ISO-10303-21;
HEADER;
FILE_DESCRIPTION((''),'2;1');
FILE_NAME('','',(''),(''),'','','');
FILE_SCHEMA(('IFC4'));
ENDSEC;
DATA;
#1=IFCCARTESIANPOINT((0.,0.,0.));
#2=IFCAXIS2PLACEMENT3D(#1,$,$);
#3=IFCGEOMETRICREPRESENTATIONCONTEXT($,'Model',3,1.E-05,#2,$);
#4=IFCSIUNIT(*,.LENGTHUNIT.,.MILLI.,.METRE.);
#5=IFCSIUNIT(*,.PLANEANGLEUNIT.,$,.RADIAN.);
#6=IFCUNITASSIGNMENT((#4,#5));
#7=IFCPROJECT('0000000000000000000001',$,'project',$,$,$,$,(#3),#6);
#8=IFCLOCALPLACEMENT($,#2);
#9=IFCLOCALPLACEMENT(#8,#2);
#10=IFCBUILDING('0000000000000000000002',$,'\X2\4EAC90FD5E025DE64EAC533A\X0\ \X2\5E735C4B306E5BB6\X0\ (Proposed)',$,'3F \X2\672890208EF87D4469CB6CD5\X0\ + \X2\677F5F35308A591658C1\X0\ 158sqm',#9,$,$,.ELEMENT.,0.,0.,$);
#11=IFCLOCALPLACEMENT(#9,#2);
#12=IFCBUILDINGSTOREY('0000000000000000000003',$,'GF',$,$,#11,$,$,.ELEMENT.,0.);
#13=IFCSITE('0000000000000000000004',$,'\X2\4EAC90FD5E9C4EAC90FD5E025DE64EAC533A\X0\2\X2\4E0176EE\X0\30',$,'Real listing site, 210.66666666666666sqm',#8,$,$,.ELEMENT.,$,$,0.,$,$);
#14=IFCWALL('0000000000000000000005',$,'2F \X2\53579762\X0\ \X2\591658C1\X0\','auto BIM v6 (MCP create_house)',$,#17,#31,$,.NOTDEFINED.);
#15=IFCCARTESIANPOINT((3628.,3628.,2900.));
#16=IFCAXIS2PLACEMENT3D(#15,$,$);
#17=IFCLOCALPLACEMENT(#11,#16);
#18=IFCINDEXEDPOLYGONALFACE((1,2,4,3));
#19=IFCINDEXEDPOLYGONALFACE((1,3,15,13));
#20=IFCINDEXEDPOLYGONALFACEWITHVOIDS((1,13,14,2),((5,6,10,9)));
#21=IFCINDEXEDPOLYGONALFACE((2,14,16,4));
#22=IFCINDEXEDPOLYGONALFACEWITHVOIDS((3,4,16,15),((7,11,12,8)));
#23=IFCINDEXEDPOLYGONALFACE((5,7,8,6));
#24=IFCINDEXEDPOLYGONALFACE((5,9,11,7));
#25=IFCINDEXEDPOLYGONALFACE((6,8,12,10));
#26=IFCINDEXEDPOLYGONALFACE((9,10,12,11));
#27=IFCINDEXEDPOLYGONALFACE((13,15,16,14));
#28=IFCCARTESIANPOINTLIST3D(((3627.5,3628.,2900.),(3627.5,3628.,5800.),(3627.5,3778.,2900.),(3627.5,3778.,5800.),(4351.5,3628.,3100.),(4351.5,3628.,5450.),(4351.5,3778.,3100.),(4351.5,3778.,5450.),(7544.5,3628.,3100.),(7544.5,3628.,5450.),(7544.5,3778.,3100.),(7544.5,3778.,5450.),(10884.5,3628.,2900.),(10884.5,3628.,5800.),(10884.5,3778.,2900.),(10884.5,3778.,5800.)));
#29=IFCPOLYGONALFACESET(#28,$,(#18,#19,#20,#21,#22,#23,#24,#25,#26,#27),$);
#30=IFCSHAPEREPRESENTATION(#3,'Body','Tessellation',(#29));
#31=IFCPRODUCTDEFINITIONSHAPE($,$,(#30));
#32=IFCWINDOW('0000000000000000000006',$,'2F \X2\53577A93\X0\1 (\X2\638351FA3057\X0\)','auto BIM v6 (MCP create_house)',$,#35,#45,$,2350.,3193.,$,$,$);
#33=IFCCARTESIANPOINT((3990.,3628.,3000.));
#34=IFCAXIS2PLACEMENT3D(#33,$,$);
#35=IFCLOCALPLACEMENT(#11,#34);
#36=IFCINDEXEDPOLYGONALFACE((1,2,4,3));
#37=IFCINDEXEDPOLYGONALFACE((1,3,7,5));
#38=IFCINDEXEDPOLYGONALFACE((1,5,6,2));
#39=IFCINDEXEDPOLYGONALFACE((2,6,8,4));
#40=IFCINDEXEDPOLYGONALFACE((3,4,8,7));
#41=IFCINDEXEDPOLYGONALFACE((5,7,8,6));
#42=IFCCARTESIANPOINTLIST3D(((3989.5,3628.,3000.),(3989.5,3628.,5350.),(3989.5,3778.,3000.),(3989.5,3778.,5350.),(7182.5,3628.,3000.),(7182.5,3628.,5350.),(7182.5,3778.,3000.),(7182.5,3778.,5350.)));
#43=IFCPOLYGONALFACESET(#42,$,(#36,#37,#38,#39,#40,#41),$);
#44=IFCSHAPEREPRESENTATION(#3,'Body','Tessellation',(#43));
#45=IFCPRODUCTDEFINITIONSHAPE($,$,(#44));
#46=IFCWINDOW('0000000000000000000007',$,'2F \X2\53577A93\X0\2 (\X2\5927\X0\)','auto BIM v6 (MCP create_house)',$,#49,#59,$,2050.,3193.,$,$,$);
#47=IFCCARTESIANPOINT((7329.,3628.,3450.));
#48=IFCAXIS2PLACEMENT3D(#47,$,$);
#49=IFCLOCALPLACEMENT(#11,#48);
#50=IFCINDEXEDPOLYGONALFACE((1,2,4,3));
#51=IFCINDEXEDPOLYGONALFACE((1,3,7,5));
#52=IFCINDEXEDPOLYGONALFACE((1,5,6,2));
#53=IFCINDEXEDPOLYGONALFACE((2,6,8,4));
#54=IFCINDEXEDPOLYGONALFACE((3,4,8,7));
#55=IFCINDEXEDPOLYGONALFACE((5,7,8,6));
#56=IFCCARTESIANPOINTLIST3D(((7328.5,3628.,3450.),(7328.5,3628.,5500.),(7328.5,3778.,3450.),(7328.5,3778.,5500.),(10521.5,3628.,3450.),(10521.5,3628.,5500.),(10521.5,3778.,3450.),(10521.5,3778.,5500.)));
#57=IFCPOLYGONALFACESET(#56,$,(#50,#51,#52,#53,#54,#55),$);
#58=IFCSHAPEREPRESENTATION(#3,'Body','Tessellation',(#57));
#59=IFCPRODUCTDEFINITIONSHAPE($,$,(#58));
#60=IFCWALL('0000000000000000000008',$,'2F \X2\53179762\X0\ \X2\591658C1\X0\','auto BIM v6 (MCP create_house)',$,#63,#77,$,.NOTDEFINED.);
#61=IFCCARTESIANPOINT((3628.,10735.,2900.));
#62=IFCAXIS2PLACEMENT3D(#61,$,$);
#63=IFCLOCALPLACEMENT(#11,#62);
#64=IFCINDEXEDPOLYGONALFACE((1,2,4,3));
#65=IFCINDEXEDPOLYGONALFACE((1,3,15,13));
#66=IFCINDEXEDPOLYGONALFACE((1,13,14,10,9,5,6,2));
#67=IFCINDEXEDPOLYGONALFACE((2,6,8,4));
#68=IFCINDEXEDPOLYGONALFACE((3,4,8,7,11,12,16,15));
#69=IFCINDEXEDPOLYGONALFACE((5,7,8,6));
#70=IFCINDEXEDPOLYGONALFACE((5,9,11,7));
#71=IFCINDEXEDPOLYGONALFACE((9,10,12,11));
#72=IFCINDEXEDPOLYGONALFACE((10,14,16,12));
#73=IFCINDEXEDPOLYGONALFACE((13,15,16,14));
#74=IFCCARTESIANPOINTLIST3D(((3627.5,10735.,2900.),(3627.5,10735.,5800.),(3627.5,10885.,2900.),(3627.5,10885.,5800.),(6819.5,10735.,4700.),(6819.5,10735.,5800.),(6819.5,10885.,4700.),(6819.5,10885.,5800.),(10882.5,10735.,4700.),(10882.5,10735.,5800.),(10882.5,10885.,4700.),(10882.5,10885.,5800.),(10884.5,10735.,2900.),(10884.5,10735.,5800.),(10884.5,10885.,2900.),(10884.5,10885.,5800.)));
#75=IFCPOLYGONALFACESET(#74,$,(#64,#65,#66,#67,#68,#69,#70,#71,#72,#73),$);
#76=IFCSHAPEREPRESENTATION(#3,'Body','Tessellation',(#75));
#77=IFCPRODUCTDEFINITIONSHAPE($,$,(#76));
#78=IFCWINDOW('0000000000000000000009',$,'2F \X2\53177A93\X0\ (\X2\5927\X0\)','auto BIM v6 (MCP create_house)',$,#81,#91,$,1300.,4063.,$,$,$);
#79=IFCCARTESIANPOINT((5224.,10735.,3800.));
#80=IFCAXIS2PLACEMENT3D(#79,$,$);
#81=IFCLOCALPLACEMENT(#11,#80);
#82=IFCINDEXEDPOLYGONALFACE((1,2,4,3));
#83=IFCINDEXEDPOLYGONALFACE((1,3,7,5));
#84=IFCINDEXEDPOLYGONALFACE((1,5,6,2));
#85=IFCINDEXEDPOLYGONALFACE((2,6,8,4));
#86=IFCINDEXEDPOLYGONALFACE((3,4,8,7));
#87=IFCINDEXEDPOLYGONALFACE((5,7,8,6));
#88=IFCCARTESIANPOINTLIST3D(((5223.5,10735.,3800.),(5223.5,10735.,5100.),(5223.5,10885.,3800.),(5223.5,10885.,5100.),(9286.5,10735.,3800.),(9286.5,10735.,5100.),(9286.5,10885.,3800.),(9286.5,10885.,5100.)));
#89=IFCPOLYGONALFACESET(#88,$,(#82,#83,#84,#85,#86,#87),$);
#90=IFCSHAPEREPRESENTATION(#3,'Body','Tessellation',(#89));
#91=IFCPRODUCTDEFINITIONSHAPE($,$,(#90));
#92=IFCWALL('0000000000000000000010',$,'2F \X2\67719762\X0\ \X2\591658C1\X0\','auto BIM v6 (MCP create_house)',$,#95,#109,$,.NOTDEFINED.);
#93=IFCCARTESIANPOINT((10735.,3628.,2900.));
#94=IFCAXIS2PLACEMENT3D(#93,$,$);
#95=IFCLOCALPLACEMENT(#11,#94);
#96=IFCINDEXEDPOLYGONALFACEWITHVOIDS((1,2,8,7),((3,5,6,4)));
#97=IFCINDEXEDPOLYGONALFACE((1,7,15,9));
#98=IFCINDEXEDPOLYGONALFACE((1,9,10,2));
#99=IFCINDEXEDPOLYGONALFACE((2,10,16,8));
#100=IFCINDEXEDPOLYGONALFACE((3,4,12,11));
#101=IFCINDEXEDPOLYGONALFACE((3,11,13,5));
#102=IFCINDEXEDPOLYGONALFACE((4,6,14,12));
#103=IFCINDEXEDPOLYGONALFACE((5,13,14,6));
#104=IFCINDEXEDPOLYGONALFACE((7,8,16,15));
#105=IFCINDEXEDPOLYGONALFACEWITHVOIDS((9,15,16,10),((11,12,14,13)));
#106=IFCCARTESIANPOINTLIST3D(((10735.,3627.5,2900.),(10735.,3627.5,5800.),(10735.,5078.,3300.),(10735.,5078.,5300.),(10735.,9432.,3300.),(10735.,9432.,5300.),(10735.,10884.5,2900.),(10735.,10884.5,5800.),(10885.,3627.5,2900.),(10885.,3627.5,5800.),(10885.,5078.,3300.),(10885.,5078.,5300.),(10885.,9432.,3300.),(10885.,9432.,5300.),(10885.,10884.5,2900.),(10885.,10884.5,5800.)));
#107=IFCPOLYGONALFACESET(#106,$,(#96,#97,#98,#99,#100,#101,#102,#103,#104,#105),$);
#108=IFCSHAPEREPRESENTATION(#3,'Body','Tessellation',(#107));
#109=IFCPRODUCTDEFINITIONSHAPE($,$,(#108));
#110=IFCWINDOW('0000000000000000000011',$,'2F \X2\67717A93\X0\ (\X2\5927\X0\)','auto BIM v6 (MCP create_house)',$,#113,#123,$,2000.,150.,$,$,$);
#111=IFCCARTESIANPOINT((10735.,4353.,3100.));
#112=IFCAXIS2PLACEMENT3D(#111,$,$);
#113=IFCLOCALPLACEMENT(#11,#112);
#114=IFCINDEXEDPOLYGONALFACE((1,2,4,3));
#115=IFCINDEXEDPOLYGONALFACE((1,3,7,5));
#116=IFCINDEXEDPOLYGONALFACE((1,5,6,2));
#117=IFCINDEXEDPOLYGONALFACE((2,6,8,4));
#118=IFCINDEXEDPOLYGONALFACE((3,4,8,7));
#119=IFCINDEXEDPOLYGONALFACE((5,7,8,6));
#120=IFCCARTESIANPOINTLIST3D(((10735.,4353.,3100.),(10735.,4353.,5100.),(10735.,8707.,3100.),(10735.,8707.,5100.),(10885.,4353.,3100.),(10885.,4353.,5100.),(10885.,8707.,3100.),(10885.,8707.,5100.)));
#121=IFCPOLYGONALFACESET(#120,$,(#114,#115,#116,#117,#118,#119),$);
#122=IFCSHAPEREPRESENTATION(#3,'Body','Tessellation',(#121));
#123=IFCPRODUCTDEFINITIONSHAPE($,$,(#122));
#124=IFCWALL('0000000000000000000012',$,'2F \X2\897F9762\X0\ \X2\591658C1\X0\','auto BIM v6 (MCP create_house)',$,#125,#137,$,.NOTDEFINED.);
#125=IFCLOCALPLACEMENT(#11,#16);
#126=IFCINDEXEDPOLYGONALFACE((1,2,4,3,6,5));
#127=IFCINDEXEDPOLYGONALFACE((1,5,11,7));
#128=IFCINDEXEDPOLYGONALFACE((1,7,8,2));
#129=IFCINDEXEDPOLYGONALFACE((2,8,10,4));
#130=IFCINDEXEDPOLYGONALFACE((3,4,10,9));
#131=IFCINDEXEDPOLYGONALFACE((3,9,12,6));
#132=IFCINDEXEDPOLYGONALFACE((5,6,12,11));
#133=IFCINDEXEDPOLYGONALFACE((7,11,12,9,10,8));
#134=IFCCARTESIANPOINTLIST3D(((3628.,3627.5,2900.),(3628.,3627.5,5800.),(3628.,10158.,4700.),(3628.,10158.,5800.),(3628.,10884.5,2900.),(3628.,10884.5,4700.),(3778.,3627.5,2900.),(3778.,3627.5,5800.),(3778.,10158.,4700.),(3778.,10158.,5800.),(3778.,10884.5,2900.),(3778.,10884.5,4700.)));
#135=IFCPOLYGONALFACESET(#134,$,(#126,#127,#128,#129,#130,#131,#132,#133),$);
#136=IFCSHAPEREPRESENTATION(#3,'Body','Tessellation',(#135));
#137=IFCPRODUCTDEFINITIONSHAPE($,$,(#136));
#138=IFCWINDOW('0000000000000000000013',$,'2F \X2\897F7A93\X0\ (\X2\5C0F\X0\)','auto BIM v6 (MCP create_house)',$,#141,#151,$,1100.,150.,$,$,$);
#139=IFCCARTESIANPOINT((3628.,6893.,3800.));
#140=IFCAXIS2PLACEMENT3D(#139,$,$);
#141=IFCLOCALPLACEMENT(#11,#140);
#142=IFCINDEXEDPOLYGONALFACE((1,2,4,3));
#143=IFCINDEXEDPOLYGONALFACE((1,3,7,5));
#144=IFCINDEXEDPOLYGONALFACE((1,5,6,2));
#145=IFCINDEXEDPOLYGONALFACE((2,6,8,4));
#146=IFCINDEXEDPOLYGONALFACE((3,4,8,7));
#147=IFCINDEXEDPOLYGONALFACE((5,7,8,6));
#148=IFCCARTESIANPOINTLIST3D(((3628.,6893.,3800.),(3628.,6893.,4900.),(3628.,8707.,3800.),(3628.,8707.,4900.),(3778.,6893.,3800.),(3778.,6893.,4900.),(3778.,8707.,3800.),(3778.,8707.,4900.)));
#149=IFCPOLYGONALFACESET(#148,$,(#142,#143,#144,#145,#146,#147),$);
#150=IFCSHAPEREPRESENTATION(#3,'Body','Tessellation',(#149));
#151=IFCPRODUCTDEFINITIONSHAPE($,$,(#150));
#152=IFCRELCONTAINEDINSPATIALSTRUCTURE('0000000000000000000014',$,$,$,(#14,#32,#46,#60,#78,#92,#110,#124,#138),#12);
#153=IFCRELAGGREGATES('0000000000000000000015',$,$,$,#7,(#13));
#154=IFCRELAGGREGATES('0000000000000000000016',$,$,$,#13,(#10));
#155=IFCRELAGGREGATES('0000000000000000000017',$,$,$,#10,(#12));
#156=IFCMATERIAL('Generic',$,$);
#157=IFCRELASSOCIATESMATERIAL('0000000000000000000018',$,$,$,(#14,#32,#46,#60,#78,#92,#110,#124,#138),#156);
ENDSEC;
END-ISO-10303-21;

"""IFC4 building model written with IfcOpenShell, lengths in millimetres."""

from ifc_helpers import new_model, si_unit, frame, frame_2d, origin, place, context, project, spatial, rectangle, extrude, material, element, fill, save


model = new_model("IFC4")

# Units and contexts
model_context = context("Model", 3, precision=1e-05, world=origin())
ifc_project = project(units=[si_unit("LENGTHUNIT", "METRE", prefix="MILLI"), si_unit("PLANEANGLEUNIT", "RADIAN")], contexts=[model_context])

# Site, building, storey
site_placement = place(None, origin())
site = spatial("IfcSite", under=ifc_project, at=site_placement, Name="京都府京都市左京区2丁目30", ObjectType="Real listing site, 210.66666666666666sqm", CompositionType="ELEMENT", RefElevation=0.0)
building_placement = place(site_placement, origin())
building = spatial("IfcBuilding", under=site, at=building_placement, Name="京都市左京区 平屋の家 (Proposed)", ObjectType="3F 木造軸組構法 + 板張り外壁 158sqm", CompositionType="ELEMENT", ElevationOfRefHeight=0.0, ElevationOfTerrain=0.0)
storey_placement = place(building_placement, origin())
storey = spatial("IfcBuildingStorey", under=building, at=storey_placement, Name="GF", CompositionType="ELEMENT", Elevation=0.0)

# Shared definitions
ifc_material = material(Name="Generic")

# Wall, openings, windows
wall_1_placement = place(storey_placement, frame((3628.0, 3628.0, 2900.0)))
wall_1 = element("IfcWall", 1, at=wall_1_placement, inside=storey, material=ifc_material, Name="2F 南面 外壁", Description="auto BIM v6 (MCP create_house)", PredefinedType="NOTDEFINED", context=model_context, shape_type="SweptSolid", body=[
    extrude(rectangle(XDim=7257.0, YDim=150.0, at=frame_2d((3628.0, 75.0))), frame((3628.0, 3628.0, 2900.0)), (0.0, 0.0, 1.0), 2900.0),
])
opening_1_placement = place(storey_placement, frame((3990.0, 3628.0, 3000.0)))
opening_1 = element("IfcOpeningElement", 2, at=opening_1_placement, cuts=wall_1, PredefinedType="NOTDEFINED", context=model_context, shape_type="SweptSolid", body=[
    extrude(rectangle(XDim=3193.0, YDim=150.0, at=frame_2d((1596.0, 75.0))), frame((3990.0, 3628.0, 3000.0)), (0.0, 0.0, 1.0), 2350.0),
])
opening_2_placement = place(storey_placement, frame((7329.0, 3628.0, 3450.0)))
opening_2 = element("IfcOpeningElement", 3, at=opening_2_placement, cuts=wall_1, PredefinedType="NOTDEFINED", context=model_context, shape_type="SweptSolid", body=[
    extrude(rectangle(XDim=3193.0, YDim=150.0, at=frame_2d((1596.0, 75.0))), frame((7329.0, 3628.0, 3450.0)), (0.0, 0.0, 1.0), 2050.0),
])
window_1_placement = place(storey_placement, frame((3990.0, 3628.0, 3000.0)))
window_1 = element("IfcWindow", 4, at=window_1_placement, inside=storey, material=ifc_material, Name="2F 南窓1 (掃出し)", Description="auto BIM v6 (MCP create_house)", OverallHeight=2350.0, OverallWidth=3193.0, context=model_context, shape_type="SweptSolid", body=[
    extrude(rectangle(XDim=3193.0, YDim=150.0, at=frame_2d((1596.0, 75.0))), frame((3990.0, 3628.0, 3000.0)), (0.0, 0.0, 1.0), 2350.0),
])
fill(opening_1, window_1)
window_2_placement = place(storey_placement, frame((7329.0, 3628.0, 3450.0)))
window_2 = element("IfcWindow", 5, at=window_2_placement, inside=storey, material=ifc_material, Name="2F 南窓2 (大)", Description="auto BIM v6 (MCP create_house)", OverallHeight=2050.0, OverallWidth=3193.0, context=model_context, shape_type="SweptSolid", body=[
    extrude(rectangle(XDim=3193.0, YDim=150.0, at=frame_2d((1596.0, 75.0))), frame((7329.0, 3628.0, 3450.0)), (0.0, 0.0, 1.0), 2050.0),
])
fill(opening_2, window_2)

# Walls, openings, windows
wall_2_placement = place(storey_placement, frame((3628.0, 10735.0, 2900.0)))
wall_2 = element("IfcWall", 6, at=wall_2_placement, inside=storey, material=ifc_material, Name="2F 北面 外壁", Description="auto BIM v6 (MCP create_house)", PredefinedType="NOTDEFINED", context=model_context, shape_type="SweptSolid", body=[
    extrude(rectangle(XDim=7257.0, YDim=150.0, at=frame_2d((3628.0, 75.0))), frame((3628.0, 10735.0, 2900.0)), (0.0, 0.0, 1.0), 2900.0),
])
opening_3_placement = place(storey_placement, frame((5224.0, 10735.0, 3800.0)))
opening_3 = element("IfcOpeningElement", 7, at=opening_3_placement, cuts=wall_2, PredefinedType="NOTDEFINED", context=model_context, shape_type="SweptSolid", body=[
    extrude(rectangle(XDim=4063.0, YDim=150.0, at=frame_2d((2031.0, 75.0))), frame((5224.0, 10735.0, 3800.0)), (0.0, 0.0, 1.0), 1300.0),
])
window_3_placement = place(storey_placement, frame((5224.0, 10735.0, 3800.0)))
window_3 = element("IfcWindow", 8, at=window_3_placement, inside=storey, material=ifc_material, Name="2F 北窓 (大)", Description="auto BIM v6 (MCP create_house)", OverallHeight=1300.0, OverallWidth=4063.0, context=model_context, shape_type="SweptSolid", body=[
    extrude(rectangle(XDim=4063.0, YDim=150.0, at=frame_2d((2031.0, 75.0))), frame((5224.0, 10735.0, 3800.0)), (0.0, 0.0, 1.0), 1300.0),
])
fill(opening_3, window_3)
wall_3_placement = place(storey_placement, frame((10735.0, 3628.0, 2900.0)))
wall_3 = element("IfcWall", 9, at=wall_3_placement, inside=storey, material=ifc_material, Name="2F 東面 外壁", Description="auto BIM v6 (MCP create_house)", PredefinedType="NOTDEFINED", context=model_context, shape_type="SweptSolid", body=[
    extrude(rectangle(XDim=150.0, YDim=7257.0, at=frame_2d((75.0, 3628.0))), frame((10735.0, 3628.0, 2900.0)), (0.0, 0.0, 1.0), 2900.0),
])
opening_4_placement = place(storey_placement, frame((10735.0, 4353.0, 3100.0)))
opening_4 = element("IfcOpeningElement", 10, at=opening_4_placement, cuts=wall_3, PredefinedType="NOTDEFINED", context=model_context, shape_type="SweptSolid", body=[
    extrude(rectangle(XDim=150.0, YDim=4354.0, at=frame_2d((75.0, 2177.0))), frame((10735.0, 4353.0, 3100.0)), (0.0, 0.0, 1.0), 2000.0),
])
window_4_placement = place(storey_placement, frame((10735.0, 4353.0, 3100.0)))
window_4 = element("IfcWindow", 11, at=window_4_placement, inside=storey, material=ifc_material, Name="2F 東窓 (大)", Description="auto BIM v6 (MCP create_house)", OverallHeight=2000.0, OverallWidth=150.0, context=model_context, shape_type="SweptSolid", body=[
    extrude(rectangle(XDim=150.0, YDim=4354.0, at=frame_2d((75.0, 2177.0))), frame((10735.0, 4353.0, 3100.0)), (0.0, 0.0, 1.0), 2000.0),
])
fill(opening_4, window_4)
wall_4_placement = place(storey_placement, frame((3628.0, 3628.0, 2900.0)))
wall_4 = element("IfcWall", 12, at=wall_4_placement, inside=storey, material=ifc_material, Name="2F 西面 外壁", Description="auto BIM v6 (MCP create_house)", PredefinedType="NOTDEFINED", context=model_context, shape_type="SweptSolid", body=[
    extrude(rectangle(XDim=150.0, YDim=7257.0, at=frame_2d((75.0, 3628.0))), frame((3628.0, 3628.0, 2900.0)), (0.0, 0.0, 1.0), 2900.0),
])
opening_5_placement = place(storey_placement, frame((3628.0, 6893.0, 3800.0)))
opening_5 = element("IfcOpeningElement", 13, at=opening_5_placement, cuts=wall_4, PredefinedType="NOTDEFINED", context=model_context, shape_type="SweptSolid", body=[
    extrude(rectangle(XDim=150.0, YDim=1814.0, at=frame_2d((75.0, 907.0))), frame((3628.0, 6893.0, 3800.0)), (0.0, 0.0, 1.0), 1100.0),
])
window_5_placement = place(storey_placement, frame((3628.0, 6893.0, 3800.0)))
window_5 = element("IfcWindow", 14, at=window_5_placement, inside=storey, material=ifc_material, Name="2F 西窓 (小)", Description="auto BIM v6 (MCP create_house)", OverallHeight=1100.0, OverallWidth=150.0, context=model_context, shape_type="SweptSolid", body=[
    extrude(rectangle(XDim=150.0, YDim=1814.0, at=frame_2d((75.0, 907.0))), frame((3628.0, 6893.0, 3800.0)), (0.0, 0.0, 1.0), 1100.0),
])
fill(opening_5, window_5)

save(model, "model.ifc")
